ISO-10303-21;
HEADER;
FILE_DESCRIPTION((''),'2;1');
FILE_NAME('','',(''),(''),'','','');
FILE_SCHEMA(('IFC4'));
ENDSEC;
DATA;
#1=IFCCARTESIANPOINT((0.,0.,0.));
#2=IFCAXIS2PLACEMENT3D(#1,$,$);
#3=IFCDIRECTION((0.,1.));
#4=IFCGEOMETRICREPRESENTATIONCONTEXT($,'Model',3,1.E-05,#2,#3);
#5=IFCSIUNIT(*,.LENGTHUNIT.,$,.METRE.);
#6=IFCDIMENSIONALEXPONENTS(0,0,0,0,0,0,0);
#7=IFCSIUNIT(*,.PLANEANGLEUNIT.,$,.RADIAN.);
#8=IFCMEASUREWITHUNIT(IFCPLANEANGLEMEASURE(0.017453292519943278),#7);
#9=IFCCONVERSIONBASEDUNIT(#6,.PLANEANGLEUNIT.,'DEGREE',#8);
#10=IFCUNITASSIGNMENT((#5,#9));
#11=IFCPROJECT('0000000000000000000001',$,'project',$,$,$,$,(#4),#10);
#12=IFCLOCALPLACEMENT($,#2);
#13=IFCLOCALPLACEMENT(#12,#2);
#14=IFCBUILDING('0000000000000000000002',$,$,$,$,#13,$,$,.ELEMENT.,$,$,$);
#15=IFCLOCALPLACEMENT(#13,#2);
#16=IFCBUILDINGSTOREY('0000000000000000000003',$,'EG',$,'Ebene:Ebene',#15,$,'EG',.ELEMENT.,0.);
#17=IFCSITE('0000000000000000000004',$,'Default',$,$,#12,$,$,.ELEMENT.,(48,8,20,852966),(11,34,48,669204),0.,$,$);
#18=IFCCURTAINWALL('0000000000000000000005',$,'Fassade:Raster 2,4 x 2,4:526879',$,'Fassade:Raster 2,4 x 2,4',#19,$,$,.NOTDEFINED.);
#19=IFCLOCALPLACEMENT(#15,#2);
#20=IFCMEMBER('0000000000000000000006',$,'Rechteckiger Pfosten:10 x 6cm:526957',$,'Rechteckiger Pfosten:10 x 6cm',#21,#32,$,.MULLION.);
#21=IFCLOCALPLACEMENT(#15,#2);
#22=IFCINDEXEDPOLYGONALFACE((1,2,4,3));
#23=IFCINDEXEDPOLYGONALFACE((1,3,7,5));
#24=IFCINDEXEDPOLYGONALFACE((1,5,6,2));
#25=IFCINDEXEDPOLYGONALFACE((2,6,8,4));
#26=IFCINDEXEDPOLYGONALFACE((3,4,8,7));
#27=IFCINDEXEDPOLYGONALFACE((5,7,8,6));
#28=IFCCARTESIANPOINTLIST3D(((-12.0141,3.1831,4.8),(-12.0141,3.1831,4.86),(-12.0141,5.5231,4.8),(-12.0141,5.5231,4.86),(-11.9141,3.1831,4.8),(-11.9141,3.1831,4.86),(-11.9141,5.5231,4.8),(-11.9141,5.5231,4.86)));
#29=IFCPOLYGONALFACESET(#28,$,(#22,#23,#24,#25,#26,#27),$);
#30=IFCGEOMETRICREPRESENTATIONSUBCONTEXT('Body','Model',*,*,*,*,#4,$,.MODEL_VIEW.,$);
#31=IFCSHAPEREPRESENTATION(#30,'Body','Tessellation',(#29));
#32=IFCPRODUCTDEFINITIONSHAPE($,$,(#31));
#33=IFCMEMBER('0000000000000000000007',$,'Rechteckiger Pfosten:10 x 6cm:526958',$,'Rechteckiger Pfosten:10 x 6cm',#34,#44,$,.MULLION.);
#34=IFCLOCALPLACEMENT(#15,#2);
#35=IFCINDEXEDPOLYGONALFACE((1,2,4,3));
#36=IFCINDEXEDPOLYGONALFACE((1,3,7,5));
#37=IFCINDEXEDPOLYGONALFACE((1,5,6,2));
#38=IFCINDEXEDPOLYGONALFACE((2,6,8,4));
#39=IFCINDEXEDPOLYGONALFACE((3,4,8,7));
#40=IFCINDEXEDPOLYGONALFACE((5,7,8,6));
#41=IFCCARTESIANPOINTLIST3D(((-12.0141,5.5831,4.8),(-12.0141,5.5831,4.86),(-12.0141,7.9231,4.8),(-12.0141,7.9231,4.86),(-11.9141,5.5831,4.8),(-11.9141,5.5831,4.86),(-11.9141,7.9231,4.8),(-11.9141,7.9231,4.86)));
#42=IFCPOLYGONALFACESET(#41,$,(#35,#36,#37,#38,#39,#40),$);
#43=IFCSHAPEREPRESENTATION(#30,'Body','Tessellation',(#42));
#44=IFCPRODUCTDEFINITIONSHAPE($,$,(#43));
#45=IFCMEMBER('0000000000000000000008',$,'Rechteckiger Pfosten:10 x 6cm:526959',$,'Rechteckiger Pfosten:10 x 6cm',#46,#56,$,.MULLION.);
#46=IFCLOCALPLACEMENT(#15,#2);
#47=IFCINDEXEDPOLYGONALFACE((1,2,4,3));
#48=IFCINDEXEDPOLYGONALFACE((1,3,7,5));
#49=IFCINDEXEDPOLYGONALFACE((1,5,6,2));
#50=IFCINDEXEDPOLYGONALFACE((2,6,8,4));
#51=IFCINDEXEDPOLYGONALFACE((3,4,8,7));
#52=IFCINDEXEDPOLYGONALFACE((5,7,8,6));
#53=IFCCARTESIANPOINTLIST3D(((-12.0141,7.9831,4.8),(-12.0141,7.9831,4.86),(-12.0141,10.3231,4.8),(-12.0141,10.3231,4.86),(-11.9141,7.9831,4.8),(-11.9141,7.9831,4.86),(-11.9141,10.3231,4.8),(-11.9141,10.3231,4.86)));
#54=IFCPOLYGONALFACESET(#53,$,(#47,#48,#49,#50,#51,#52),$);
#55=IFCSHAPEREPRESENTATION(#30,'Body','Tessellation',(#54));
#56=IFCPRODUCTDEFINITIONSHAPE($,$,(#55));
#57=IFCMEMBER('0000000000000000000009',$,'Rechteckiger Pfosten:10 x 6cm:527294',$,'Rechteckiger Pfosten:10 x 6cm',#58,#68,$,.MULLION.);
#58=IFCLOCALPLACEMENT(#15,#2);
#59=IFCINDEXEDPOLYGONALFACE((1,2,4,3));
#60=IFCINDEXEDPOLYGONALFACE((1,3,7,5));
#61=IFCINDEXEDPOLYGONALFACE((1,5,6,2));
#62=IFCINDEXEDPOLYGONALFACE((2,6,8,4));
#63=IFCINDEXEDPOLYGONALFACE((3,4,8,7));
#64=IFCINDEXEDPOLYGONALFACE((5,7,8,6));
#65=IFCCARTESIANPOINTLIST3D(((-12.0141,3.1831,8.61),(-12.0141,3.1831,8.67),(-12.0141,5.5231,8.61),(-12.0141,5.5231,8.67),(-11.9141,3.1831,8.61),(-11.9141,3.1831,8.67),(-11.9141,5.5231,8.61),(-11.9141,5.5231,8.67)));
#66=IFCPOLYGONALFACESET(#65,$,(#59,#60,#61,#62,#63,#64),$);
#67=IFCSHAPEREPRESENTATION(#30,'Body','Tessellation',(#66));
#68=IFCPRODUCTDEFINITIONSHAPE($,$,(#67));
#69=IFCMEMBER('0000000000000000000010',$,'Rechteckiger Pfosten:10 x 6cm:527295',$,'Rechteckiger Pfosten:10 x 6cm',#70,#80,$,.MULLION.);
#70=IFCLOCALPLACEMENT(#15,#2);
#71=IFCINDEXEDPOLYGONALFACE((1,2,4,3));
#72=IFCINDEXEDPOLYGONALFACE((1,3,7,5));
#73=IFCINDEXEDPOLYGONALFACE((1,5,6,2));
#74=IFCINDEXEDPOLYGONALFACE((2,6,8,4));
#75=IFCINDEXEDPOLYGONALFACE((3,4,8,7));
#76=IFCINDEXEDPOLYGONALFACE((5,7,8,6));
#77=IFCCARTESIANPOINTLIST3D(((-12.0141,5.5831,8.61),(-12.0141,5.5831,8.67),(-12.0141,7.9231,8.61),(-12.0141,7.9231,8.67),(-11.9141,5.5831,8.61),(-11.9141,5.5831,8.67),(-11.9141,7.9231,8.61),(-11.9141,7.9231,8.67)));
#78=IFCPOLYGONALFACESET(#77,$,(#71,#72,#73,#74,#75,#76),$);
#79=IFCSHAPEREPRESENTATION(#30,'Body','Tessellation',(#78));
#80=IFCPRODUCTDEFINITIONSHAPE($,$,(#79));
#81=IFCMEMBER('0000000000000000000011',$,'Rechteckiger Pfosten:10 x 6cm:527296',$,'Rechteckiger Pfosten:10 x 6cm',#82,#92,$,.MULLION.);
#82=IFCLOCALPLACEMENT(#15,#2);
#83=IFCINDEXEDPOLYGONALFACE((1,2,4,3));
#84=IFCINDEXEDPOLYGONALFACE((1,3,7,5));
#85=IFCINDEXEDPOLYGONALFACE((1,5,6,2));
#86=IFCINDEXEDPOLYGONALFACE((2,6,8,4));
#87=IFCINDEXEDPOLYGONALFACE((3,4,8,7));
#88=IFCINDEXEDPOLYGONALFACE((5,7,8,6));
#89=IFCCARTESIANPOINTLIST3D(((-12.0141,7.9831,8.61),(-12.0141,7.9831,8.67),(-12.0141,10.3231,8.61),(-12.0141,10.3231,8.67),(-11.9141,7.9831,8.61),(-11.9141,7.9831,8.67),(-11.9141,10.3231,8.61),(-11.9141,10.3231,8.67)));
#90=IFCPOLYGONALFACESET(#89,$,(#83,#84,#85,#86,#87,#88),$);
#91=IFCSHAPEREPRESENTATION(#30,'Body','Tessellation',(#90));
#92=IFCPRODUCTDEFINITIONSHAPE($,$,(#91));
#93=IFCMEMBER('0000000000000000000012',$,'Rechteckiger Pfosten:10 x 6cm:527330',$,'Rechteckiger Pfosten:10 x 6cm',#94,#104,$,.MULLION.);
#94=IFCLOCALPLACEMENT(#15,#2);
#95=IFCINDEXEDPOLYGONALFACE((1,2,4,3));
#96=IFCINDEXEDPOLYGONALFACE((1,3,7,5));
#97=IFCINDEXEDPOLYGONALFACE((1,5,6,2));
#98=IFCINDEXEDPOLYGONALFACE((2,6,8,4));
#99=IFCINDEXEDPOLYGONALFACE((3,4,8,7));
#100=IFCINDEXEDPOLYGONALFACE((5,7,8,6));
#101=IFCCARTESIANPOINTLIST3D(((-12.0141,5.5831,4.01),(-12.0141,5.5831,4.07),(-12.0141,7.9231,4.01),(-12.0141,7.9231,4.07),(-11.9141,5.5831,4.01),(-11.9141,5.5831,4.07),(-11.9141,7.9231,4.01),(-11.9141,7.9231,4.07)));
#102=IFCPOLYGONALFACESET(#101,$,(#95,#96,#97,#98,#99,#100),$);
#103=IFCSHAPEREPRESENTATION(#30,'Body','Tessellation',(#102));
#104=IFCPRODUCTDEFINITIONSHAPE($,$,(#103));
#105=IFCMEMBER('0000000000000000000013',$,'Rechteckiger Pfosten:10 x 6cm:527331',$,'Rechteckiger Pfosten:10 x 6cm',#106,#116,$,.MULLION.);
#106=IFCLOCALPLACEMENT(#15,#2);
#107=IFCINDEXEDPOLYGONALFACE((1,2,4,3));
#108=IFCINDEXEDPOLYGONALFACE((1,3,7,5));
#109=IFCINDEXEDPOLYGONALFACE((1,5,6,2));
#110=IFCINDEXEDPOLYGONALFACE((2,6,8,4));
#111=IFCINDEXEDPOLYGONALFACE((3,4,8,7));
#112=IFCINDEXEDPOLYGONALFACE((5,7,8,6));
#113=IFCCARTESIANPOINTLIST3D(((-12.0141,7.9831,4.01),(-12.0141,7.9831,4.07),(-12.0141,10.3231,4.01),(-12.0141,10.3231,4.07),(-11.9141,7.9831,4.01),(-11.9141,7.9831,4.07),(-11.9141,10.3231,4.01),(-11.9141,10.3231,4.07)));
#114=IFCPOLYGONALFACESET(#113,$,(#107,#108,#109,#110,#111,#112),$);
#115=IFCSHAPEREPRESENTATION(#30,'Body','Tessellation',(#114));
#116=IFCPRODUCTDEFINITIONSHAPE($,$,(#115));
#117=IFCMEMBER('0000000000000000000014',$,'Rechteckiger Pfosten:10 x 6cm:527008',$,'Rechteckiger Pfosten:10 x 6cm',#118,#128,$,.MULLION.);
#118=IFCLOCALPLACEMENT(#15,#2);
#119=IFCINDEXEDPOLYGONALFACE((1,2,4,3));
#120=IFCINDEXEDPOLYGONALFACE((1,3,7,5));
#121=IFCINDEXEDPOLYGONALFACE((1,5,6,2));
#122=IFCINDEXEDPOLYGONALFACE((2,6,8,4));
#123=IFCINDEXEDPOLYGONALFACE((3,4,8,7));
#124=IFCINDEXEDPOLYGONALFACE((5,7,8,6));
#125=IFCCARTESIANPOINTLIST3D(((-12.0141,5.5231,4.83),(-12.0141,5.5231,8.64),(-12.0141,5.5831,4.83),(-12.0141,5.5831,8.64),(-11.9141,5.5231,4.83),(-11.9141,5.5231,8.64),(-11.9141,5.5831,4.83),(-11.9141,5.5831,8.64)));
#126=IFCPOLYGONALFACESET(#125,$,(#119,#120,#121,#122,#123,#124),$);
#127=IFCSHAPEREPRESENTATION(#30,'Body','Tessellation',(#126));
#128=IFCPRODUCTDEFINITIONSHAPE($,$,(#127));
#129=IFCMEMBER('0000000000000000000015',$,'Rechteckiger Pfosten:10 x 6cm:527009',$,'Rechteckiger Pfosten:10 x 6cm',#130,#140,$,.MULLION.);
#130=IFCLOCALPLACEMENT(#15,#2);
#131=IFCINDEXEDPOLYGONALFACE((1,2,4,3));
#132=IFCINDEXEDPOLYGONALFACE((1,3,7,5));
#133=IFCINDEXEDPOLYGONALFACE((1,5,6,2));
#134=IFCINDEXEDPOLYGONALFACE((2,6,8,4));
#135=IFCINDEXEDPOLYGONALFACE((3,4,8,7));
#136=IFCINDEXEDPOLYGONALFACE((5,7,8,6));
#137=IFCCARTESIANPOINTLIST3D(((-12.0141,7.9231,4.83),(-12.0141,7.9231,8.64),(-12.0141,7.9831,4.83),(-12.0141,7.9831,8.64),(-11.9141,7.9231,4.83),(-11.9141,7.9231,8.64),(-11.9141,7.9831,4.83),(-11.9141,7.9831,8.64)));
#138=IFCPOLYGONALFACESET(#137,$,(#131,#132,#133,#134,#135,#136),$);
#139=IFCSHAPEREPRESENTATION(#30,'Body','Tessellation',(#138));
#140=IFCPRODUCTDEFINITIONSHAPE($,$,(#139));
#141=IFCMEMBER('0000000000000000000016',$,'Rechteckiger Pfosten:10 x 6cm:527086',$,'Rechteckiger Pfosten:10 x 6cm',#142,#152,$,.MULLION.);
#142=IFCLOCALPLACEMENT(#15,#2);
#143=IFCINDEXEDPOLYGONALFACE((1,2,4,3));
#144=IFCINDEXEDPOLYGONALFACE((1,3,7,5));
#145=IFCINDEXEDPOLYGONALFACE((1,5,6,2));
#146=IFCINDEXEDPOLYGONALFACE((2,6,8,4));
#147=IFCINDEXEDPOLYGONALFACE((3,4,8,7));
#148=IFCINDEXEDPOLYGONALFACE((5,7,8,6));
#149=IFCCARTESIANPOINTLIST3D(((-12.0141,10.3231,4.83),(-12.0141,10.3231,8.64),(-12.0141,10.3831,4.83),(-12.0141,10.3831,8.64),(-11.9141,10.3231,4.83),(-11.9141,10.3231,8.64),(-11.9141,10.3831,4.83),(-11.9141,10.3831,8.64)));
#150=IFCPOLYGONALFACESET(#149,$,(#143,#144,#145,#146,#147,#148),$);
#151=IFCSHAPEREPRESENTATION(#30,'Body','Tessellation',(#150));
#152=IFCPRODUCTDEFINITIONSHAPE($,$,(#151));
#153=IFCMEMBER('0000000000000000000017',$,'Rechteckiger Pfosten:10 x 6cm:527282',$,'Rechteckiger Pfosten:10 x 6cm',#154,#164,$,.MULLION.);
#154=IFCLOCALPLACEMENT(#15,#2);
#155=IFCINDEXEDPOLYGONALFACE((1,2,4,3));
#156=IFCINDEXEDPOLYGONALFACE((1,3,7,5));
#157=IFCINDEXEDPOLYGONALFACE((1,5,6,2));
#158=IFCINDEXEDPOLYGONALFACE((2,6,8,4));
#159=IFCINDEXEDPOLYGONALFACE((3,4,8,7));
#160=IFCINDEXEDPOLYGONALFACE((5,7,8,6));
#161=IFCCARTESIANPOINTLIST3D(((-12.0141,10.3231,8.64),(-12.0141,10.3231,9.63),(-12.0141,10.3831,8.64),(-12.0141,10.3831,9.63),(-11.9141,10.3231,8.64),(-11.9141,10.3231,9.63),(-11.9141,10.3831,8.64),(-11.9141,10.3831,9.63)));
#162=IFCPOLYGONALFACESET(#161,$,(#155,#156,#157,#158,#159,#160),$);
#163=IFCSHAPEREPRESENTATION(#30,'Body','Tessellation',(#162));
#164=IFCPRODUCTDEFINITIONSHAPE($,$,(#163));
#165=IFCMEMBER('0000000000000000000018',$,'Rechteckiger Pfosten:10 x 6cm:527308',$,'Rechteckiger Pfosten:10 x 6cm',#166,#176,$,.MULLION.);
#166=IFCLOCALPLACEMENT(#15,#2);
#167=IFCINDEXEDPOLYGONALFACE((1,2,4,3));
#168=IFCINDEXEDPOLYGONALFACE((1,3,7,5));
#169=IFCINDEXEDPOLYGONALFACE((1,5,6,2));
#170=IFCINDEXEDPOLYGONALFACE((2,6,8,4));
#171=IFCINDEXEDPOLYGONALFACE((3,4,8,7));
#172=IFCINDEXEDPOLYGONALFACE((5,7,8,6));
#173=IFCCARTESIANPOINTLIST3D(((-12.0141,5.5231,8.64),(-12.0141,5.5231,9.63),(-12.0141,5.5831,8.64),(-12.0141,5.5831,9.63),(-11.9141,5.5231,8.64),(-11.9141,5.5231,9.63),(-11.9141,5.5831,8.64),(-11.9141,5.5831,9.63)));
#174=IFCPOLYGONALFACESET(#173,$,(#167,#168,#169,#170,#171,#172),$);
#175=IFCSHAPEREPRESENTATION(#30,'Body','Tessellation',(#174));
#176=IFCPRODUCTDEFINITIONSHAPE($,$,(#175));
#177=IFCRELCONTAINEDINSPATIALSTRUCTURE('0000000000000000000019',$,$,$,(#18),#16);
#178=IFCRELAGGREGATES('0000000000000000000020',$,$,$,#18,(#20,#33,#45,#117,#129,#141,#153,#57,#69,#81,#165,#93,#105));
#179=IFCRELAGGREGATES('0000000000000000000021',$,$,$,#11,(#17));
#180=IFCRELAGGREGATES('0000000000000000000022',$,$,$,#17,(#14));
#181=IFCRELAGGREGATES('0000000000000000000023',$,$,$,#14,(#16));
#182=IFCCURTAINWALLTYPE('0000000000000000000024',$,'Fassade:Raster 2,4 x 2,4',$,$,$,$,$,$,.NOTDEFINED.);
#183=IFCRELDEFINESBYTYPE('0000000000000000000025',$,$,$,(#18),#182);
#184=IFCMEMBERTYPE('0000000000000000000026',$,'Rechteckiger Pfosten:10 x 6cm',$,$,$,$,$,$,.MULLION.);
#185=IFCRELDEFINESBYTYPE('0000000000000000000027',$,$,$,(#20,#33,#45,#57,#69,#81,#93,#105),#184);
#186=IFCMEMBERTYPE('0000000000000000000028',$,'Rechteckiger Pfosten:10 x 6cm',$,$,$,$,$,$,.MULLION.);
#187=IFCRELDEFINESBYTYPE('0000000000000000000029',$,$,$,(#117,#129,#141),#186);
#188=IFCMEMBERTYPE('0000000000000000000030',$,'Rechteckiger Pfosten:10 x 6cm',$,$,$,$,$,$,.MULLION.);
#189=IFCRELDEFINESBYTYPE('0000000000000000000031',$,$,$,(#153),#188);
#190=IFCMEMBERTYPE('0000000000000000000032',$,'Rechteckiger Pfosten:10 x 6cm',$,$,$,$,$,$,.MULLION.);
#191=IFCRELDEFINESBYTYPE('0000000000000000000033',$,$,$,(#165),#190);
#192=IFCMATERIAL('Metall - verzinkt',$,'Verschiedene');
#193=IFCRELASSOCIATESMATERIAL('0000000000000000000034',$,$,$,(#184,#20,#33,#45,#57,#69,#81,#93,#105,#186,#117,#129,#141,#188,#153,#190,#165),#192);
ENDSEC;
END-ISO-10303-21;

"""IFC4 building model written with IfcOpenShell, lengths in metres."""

from ifc_helpers import new_model, entity, si_unit, converted_unit, direction, frame, origin, place, context, subcontext, project, spatial, indexed_curve, outline, extrude, source, transform, mapped, material, type_object, type_shapes, element, aggregate, save


model = new_model("IFC4")

# Units and contexts
model_context = context("Model", 3, precision=1e-05, world=origin(), true_north=direction((0.0, 1.0)))
body_context = subcontext(model_context, "Body", "Model", "MODEL_VIEW")
ifc_project = project(units=[si_unit("LENGTHUNIT", "METRE"), converted_unit("PLANEANGLEUNIT", "DEGREE", entity("IfcPlaneAngleMeasure", 0.017453292519943278), si_unit("PLANEANGLEUNIT", "RADIAN"), dimensions=[0, 0, 0, 0, 0, 0, 0])], contexts=[model_context])

# Site, building, storey
site_placement = place(None, origin())
site = spatial("IfcSite", under=ifc_project, at=site_placement, Name="Default", CompositionType="ELEMENT", RefLatitude=(48, 8, 20, 852966), RefLongitude=(11, 34, 48, 669204), RefElevation=0.0)
building_placement = place(site_placement, origin())
building = spatial("IfcBuilding", under=site, at=building_placement, CompositionType="ELEMENT")
storey_placement = place(building_placement, origin())
storey = spatial("IfcBuildingStorey", under=building, at=storey_placement, Name="EG", ObjectType="Ebene:Ebene", LongName="EG", CompositionType="ELEMENT", Elevation=0.0)

# Curtain wall, members
curtain_wall_type = type_object("IfcCurtainWallType", Name="Fassade:Raster 2,4 x 2,4", PredefinedType="NOTDEFINED")
curtain_wall_placement = place(storey_placement, origin())
curtain_wall = element("IfcCurtainWall", 1, at=curtain_wall_placement, inside=storey, type_object=curtain_wall_type, Name="Fassade:Raster 2,4 x 2,4:526879", ObjectType="Fassade:Raster 2,4 x 2,4", PredefinedType="NOTDEFINED")
ifc_material_1 = material(Name="Metall - verzinkt", Category="Verschiedene")
member_type_1 = type_object("IfcMemberType", Name="Rechteckiger Pfosten:10 x 6cm", PredefinedType="MULLION", material=ifc_material_1)
shared_shape_1 = source(origin(), body_context, "Body", "SweptSolid", [
    extrude(outline(indexed_curve([(-0.03, -0.05), (0.03, -0.05), (0.03, 0.05), (-0.03, 0.05), (-0.03, -0.05)], self_intersect=False)), frame((0.0, 0.0, -2.34), z_axis=(0.0, 0.0, 1.0), x_axis=(-1.0, 0.0, 0.0)), (0.0, 0.0, 1.0), 2.34),
])
type_shapes(member_type_1, [shared_shape_1])
member_1_placement = place(curtain_wall_placement, frame((-11.9641, 5.5231, 4.83), z_axis=(0.0, 1.0, 0.0), x_axis=(0.0, 0.0, 1.0)))
member_1 = element("IfcMember", 2, at=member_1_placement, type_object=member_type_1, material=ifc_material_1, Name="Rechteckiger Pfosten:10 x 6cm:526957", ObjectType="Rechteckiger Pfosten:10 x 6cm", PredefinedType="MULLION", context=body_context, shape_type="MappedRepresentation", body=[
    mapped(shared_shape_1, transform((0.0, 0.0, 0.0), scale=1.0)),
])
member_2_placement = place(curtain_wall_placement, frame((-11.9641, 7.9231, 4.83), z_axis=(0.0, 1.0, 0.0), x_axis=(0.0, 0.0, 1.0)))
member_2 = element("IfcMember", 3, at=member_2_placement, type_object=member_type_1, material=ifc_material_1, Name="Rechteckiger Pfosten:10 x 6cm:526958", ObjectType="Rechteckiger Pfosten:10 x 6cm", PredefinedType="MULLION", context=body_context, shape_type="MappedRepresentation", body=[
    mapped(shared_shape_1, transform((0.0, 0.0, 0.0), scale=1.0)),
])
member_3_placement = place(curtain_wall_placement, frame((-11.9641, 10.3231, 4.83), z_axis=(0.0, 1.0, 0.0), x_axis=(0.0, 0.0, 1.0)))
member_3 = element("IfcMember", 4, at=member_3_placement, type_object=member_type_1, material=ifc_material_1, Name="Rechteckiger Pfosten:10 x 6cm:526959", ObjectType="Rechteckiger Pfosten:10 x 6cm", PredefinedType="MULLION", context=body_context, shape_type="MappedRepresentation", body=[
    mapped(shared_shape_1, transform((0.0, 0.0, 0.0), scale=1.0)),
])
member_4_placement = place(curtain_wall_placement, frame((-11.9641, 5.5231, 8.64), z_axis=(0.0, 1.0, 0.0), x_axis=(0.0, 0.0, 1.0)))
member_4 = element("IfcMember", 5, at=member_4_placement, type_object=member_type_1, material=ifc_material_1, Name="Rechteckiger Pfosten:10 x 6cm:527294", ObjectType="Rechteckiger Pfosten:10 x 6cm", PredefinedType="MULLION", context=body_context, shape_type="MappedRepresentation", body=[
    mapped(shared_shape_1, transform((0.0, 0.0, 0.0), scale=1.0)),
])
member_5_placement = place(curtain_wall_placement, frame((-11.9641, 7.9231, 8.64), z_axis=(0.0, 1.0, 0.0), x_axis=(0.0, 0.0, 1.0)))
member_5 = element("IfcMember", 6, at=member_5_placement, type_object=member_type_1, material=ifc_material_1, Name="Rechteckiger Pfosten:10 x 6cm:527295", ObjectType="Rechteckiger Pfosten:10 x 6cm", PredefinedType="MULLION", context=body_context, shape_type="MappedRepresentation", body=[
    mapped(shared_shape_1, transform((0.0, 0.0, 0.0), scale=1.0)),
])
member_6_placement = place(curtain_wall_placement, frame((-11.9641, 10.3231, 8.64), z_axis=(0.0, 1.0, 0.0), x_axis=(0.0, 0.0, 1.0)))
member_6 = element("IfcMember", 7, at=member_6_placement, type_object=member_type_1, material=ifc_material_1, Name="Rechteckiger Pfosten:10 x 6cm:527296", ObjectType="Rechteckiger Pfosten:10 x 6cm", PredefinedType="MULLION", context=body_context, shape_type="MappedRepresentation", body=[
    mapped(shared_shape_1, transform((0.0, 0.0, 0.0), scale=1.0)),
])
member_7_placement = place(curtain_wall_placement, frame((-11.9641, 7.9231, 4.04), z_axis=(0.0, 1.0, 0.0), x_axis=(0.0, 0.0, 1.0)))
member_7 = element("IfcMember", 8, at=member_7_placement, type_object=member_type_1, material=ifc_material_1, Name="Rechteckiger Pfosten:10 x 6cm:527330", ObjectType="Rechteckiger Pfosten:10 x 6cm", PredefinedType="MULLION", context=body_context, shape_type="MappedRepresentation", body=[
    mapped(shared_shape_1, transform((0.0, 0.0, 0.0), scale=1.0)),
])
member_8_placement = place(curtain_wall_placement, frame((-11.9641, 10.3231, 4.04), z_axis=(0.0, 1.0, 0.0), x_axis=(0.0, 0.0, 1.0)))
member_8 = element("IfcMember", 9, at=member_8_placement, type_object=member_type_1, material=ifc_material_1, Name="Rechteckiger Pfosten:10 x 6cm:527331", ObjectType="Rechteckiger Pfosten:10 x 6cm", PredefinedType="MULLION", context=body_context, shape_type="MappedRepresentation", body=[
    mapped(shared_shape_1, transform((0.0, 0.0, 0.0), scale=1.0)),
])
member_type_2 = type_object("IfcMemberType", Name="Rechteckiger Pfosten:10 x 6cm", PredefinedType="MULLION", material=ifc_material_1)
shared_shape_2 = source(origin(), body_context, "Body", "SweptSolid", [
    extrude(outline(indexed_curve([(-0.03, -0.05), (0.03, -0.05), (0.03, 0.05), (-0.03, 0.05), (-0.03, -0.05)], self_intersect=False)), frame((0.0, 0.0, -3.81), z_axis=(0.0, 0.0, 1.0), x_axis=(-1.0, 0.0, 0.0)), (0.0, 0.0, 1.0), 3.81),
])
type_shapes(member_type_2, [shared_shape_2])
member_9_placement = place(curtain_wall_placement, frame((-11.9641, 5.5531, 4.83), z_axis=(0.0, 0.0, -1.0), x_axis=(0.0, 1.0, 0.0)))
member_9 = element("IfcMember", 10, at=member_9_placement, type_object=member_type_2, material=ifc_material_1, Name="Rechteckiger Pfosten:10 x 6cm:527008", ObjectType="Rechteckiger Pfosten:10 x 6cm", PredefinedType="MULLION", context=body_context, shape_type="MappedRepresentation", body=[
    mapped(shared_shape_2, transform((0.0, 0.0, 0.0), scale=1.0)),
])
member_10_placement = place(curtain_wall_placement, frame((-11.9641, 7.9531, 4.83), z_axis=(0.0, 0.0, -1.0), x_axis=(0.0, 1.0, 0.0)))
member_10 = element("IfcMember", 11, at=member_10_placement, type_object=member_type_2, material=ifc_material_1, Name="Rechteckiger Pfosten:10 x 6cm:527009", ObjectType="Rechteckiger Pfosten:10 x 6cm", PredefinedType="MULLION", context=body_context, shape_type="MappedRepresentation", body=[
    mapped(shared_shape_2, transform((0.0, 0.0, 0.0), scale=1.0)),
])
member_11_placement = place(curtain_wall_placement, frame((-11.9641, 10.3531, 4.83), z_axis=(0.0, 0.0, -1.0), x_axis=(0.0, 1.0, 0.0)))
member_11 = element("IfcMember", 12, at=member_11_placement, type_object=member_type_2, material=ifc_material_1, Name="Rechteckiger Pfosten:10 x 6cm:527086", ObjectType="Rechteckiger Pfosten:10 x 6cm", PredefinedType="MULLION", context=body_context, shape_type="MappedRepresentation", body=[
    mapped(shared_shape_2, transform((0.0, 0.0, 0.0), scale=1.0)),
])
member_type_3 = type_object("IfcMemberType", Name="Rechteckiger Pfosten:10 x 6cm", PredefinedType="MULLION", material=ifc_material_1)
shared_shape_3 = source(origin(), body_context, "Body", "SweptSolid", [
    extrude(outline(indexed_curve([(-0.03, -0.05), (0.03, -0.05), (0.03, 0.05), (-0.03, 0.05), (-0.03, -0.05)], self_intersect=False)), frame((-0.03, 0.0, -0.99), z_axis=(0.0, 0.0, 1.0), x_axis=(-1.0, 0.0, 0.0)), (0.0, 0.0, 1.0), 0.99),
])
type_shapes(member_type_3, [shared_shape_3])
member_12_placement = place(curtain_wall_placement, frame((-11.9641, 10.3831, 8.64), z_axis=(0.0, 0.0, -1.0), x_axis=(0.0, 1.0, 0.0)))
member_12 = element("IfcMember", 13, at=member_12_placement, type_object=member_type_3, material=ifc_material_1, Name="Rechteckiger Pfosten:10 x 6cm:527282", ObjectType="Rechteckiger Pfosten:10 x 6cm", PredefinedType="MULLION", context=body_context, shape_type="MappedRepresentation", body=[
    mapped(shared_shape_3, transform((0.0, 0.0, 0.0), scale=1.0)),
])
member_type_4 = type_object("IfcMemberType", Name="Rechteckiger Pfosten:10 x 6cm", PredefinedType="MULLION", material=ifc_material_1)
shared_shape_4 = source(origin(), body_context, "Body", "SweptSolid", [
    extrude(outline(indexed_curve([(-0.03, -0.05), (0.03, -0.05), (0.03, 0.05), (-0.03, 0.05), (-0.03, -0.05)], self_intersect=False)), frame((0.0, 0.0, -0.99), z_axis=(0.0, 0.0, 1.0), x_axis=(-1.0, 0.0, 0.0)), (0.0, 0.0, 1.0), 0.99),
])
type_shapes(member_type_4, [shared_shape_4])
member_13_placement = place(curtain_wall_placement, frame((-11.9641, 5.5531, 8.64), z_axis=(0.0, 0.0, -1.0), x_axis=(0.0, 1.0, 0.0)))
member_13 = element("IfcMember", 14, at=member_13_placement, type_object=member_type_4, material=ifc_material_1, Name="Rechteckiger Pfosten:10 x 6cm:527308", ObjectType="Rechteckiger Pfosten:10 x 6cm", PredefinedType="MULLION", context=body_context, shape_type="MappedRepresentation", body=[
    mapped(shared_shape_4, transform((0.0, 0.0, 0.0), scale=1.0)),
])
aggregate(curtain_wall, [member_1, member_2, member_3, member_9, member_10, member_11, member_12, member_4, member_5, member_6, member_13, member_7, member_8])

save(model, "model.ifc")
